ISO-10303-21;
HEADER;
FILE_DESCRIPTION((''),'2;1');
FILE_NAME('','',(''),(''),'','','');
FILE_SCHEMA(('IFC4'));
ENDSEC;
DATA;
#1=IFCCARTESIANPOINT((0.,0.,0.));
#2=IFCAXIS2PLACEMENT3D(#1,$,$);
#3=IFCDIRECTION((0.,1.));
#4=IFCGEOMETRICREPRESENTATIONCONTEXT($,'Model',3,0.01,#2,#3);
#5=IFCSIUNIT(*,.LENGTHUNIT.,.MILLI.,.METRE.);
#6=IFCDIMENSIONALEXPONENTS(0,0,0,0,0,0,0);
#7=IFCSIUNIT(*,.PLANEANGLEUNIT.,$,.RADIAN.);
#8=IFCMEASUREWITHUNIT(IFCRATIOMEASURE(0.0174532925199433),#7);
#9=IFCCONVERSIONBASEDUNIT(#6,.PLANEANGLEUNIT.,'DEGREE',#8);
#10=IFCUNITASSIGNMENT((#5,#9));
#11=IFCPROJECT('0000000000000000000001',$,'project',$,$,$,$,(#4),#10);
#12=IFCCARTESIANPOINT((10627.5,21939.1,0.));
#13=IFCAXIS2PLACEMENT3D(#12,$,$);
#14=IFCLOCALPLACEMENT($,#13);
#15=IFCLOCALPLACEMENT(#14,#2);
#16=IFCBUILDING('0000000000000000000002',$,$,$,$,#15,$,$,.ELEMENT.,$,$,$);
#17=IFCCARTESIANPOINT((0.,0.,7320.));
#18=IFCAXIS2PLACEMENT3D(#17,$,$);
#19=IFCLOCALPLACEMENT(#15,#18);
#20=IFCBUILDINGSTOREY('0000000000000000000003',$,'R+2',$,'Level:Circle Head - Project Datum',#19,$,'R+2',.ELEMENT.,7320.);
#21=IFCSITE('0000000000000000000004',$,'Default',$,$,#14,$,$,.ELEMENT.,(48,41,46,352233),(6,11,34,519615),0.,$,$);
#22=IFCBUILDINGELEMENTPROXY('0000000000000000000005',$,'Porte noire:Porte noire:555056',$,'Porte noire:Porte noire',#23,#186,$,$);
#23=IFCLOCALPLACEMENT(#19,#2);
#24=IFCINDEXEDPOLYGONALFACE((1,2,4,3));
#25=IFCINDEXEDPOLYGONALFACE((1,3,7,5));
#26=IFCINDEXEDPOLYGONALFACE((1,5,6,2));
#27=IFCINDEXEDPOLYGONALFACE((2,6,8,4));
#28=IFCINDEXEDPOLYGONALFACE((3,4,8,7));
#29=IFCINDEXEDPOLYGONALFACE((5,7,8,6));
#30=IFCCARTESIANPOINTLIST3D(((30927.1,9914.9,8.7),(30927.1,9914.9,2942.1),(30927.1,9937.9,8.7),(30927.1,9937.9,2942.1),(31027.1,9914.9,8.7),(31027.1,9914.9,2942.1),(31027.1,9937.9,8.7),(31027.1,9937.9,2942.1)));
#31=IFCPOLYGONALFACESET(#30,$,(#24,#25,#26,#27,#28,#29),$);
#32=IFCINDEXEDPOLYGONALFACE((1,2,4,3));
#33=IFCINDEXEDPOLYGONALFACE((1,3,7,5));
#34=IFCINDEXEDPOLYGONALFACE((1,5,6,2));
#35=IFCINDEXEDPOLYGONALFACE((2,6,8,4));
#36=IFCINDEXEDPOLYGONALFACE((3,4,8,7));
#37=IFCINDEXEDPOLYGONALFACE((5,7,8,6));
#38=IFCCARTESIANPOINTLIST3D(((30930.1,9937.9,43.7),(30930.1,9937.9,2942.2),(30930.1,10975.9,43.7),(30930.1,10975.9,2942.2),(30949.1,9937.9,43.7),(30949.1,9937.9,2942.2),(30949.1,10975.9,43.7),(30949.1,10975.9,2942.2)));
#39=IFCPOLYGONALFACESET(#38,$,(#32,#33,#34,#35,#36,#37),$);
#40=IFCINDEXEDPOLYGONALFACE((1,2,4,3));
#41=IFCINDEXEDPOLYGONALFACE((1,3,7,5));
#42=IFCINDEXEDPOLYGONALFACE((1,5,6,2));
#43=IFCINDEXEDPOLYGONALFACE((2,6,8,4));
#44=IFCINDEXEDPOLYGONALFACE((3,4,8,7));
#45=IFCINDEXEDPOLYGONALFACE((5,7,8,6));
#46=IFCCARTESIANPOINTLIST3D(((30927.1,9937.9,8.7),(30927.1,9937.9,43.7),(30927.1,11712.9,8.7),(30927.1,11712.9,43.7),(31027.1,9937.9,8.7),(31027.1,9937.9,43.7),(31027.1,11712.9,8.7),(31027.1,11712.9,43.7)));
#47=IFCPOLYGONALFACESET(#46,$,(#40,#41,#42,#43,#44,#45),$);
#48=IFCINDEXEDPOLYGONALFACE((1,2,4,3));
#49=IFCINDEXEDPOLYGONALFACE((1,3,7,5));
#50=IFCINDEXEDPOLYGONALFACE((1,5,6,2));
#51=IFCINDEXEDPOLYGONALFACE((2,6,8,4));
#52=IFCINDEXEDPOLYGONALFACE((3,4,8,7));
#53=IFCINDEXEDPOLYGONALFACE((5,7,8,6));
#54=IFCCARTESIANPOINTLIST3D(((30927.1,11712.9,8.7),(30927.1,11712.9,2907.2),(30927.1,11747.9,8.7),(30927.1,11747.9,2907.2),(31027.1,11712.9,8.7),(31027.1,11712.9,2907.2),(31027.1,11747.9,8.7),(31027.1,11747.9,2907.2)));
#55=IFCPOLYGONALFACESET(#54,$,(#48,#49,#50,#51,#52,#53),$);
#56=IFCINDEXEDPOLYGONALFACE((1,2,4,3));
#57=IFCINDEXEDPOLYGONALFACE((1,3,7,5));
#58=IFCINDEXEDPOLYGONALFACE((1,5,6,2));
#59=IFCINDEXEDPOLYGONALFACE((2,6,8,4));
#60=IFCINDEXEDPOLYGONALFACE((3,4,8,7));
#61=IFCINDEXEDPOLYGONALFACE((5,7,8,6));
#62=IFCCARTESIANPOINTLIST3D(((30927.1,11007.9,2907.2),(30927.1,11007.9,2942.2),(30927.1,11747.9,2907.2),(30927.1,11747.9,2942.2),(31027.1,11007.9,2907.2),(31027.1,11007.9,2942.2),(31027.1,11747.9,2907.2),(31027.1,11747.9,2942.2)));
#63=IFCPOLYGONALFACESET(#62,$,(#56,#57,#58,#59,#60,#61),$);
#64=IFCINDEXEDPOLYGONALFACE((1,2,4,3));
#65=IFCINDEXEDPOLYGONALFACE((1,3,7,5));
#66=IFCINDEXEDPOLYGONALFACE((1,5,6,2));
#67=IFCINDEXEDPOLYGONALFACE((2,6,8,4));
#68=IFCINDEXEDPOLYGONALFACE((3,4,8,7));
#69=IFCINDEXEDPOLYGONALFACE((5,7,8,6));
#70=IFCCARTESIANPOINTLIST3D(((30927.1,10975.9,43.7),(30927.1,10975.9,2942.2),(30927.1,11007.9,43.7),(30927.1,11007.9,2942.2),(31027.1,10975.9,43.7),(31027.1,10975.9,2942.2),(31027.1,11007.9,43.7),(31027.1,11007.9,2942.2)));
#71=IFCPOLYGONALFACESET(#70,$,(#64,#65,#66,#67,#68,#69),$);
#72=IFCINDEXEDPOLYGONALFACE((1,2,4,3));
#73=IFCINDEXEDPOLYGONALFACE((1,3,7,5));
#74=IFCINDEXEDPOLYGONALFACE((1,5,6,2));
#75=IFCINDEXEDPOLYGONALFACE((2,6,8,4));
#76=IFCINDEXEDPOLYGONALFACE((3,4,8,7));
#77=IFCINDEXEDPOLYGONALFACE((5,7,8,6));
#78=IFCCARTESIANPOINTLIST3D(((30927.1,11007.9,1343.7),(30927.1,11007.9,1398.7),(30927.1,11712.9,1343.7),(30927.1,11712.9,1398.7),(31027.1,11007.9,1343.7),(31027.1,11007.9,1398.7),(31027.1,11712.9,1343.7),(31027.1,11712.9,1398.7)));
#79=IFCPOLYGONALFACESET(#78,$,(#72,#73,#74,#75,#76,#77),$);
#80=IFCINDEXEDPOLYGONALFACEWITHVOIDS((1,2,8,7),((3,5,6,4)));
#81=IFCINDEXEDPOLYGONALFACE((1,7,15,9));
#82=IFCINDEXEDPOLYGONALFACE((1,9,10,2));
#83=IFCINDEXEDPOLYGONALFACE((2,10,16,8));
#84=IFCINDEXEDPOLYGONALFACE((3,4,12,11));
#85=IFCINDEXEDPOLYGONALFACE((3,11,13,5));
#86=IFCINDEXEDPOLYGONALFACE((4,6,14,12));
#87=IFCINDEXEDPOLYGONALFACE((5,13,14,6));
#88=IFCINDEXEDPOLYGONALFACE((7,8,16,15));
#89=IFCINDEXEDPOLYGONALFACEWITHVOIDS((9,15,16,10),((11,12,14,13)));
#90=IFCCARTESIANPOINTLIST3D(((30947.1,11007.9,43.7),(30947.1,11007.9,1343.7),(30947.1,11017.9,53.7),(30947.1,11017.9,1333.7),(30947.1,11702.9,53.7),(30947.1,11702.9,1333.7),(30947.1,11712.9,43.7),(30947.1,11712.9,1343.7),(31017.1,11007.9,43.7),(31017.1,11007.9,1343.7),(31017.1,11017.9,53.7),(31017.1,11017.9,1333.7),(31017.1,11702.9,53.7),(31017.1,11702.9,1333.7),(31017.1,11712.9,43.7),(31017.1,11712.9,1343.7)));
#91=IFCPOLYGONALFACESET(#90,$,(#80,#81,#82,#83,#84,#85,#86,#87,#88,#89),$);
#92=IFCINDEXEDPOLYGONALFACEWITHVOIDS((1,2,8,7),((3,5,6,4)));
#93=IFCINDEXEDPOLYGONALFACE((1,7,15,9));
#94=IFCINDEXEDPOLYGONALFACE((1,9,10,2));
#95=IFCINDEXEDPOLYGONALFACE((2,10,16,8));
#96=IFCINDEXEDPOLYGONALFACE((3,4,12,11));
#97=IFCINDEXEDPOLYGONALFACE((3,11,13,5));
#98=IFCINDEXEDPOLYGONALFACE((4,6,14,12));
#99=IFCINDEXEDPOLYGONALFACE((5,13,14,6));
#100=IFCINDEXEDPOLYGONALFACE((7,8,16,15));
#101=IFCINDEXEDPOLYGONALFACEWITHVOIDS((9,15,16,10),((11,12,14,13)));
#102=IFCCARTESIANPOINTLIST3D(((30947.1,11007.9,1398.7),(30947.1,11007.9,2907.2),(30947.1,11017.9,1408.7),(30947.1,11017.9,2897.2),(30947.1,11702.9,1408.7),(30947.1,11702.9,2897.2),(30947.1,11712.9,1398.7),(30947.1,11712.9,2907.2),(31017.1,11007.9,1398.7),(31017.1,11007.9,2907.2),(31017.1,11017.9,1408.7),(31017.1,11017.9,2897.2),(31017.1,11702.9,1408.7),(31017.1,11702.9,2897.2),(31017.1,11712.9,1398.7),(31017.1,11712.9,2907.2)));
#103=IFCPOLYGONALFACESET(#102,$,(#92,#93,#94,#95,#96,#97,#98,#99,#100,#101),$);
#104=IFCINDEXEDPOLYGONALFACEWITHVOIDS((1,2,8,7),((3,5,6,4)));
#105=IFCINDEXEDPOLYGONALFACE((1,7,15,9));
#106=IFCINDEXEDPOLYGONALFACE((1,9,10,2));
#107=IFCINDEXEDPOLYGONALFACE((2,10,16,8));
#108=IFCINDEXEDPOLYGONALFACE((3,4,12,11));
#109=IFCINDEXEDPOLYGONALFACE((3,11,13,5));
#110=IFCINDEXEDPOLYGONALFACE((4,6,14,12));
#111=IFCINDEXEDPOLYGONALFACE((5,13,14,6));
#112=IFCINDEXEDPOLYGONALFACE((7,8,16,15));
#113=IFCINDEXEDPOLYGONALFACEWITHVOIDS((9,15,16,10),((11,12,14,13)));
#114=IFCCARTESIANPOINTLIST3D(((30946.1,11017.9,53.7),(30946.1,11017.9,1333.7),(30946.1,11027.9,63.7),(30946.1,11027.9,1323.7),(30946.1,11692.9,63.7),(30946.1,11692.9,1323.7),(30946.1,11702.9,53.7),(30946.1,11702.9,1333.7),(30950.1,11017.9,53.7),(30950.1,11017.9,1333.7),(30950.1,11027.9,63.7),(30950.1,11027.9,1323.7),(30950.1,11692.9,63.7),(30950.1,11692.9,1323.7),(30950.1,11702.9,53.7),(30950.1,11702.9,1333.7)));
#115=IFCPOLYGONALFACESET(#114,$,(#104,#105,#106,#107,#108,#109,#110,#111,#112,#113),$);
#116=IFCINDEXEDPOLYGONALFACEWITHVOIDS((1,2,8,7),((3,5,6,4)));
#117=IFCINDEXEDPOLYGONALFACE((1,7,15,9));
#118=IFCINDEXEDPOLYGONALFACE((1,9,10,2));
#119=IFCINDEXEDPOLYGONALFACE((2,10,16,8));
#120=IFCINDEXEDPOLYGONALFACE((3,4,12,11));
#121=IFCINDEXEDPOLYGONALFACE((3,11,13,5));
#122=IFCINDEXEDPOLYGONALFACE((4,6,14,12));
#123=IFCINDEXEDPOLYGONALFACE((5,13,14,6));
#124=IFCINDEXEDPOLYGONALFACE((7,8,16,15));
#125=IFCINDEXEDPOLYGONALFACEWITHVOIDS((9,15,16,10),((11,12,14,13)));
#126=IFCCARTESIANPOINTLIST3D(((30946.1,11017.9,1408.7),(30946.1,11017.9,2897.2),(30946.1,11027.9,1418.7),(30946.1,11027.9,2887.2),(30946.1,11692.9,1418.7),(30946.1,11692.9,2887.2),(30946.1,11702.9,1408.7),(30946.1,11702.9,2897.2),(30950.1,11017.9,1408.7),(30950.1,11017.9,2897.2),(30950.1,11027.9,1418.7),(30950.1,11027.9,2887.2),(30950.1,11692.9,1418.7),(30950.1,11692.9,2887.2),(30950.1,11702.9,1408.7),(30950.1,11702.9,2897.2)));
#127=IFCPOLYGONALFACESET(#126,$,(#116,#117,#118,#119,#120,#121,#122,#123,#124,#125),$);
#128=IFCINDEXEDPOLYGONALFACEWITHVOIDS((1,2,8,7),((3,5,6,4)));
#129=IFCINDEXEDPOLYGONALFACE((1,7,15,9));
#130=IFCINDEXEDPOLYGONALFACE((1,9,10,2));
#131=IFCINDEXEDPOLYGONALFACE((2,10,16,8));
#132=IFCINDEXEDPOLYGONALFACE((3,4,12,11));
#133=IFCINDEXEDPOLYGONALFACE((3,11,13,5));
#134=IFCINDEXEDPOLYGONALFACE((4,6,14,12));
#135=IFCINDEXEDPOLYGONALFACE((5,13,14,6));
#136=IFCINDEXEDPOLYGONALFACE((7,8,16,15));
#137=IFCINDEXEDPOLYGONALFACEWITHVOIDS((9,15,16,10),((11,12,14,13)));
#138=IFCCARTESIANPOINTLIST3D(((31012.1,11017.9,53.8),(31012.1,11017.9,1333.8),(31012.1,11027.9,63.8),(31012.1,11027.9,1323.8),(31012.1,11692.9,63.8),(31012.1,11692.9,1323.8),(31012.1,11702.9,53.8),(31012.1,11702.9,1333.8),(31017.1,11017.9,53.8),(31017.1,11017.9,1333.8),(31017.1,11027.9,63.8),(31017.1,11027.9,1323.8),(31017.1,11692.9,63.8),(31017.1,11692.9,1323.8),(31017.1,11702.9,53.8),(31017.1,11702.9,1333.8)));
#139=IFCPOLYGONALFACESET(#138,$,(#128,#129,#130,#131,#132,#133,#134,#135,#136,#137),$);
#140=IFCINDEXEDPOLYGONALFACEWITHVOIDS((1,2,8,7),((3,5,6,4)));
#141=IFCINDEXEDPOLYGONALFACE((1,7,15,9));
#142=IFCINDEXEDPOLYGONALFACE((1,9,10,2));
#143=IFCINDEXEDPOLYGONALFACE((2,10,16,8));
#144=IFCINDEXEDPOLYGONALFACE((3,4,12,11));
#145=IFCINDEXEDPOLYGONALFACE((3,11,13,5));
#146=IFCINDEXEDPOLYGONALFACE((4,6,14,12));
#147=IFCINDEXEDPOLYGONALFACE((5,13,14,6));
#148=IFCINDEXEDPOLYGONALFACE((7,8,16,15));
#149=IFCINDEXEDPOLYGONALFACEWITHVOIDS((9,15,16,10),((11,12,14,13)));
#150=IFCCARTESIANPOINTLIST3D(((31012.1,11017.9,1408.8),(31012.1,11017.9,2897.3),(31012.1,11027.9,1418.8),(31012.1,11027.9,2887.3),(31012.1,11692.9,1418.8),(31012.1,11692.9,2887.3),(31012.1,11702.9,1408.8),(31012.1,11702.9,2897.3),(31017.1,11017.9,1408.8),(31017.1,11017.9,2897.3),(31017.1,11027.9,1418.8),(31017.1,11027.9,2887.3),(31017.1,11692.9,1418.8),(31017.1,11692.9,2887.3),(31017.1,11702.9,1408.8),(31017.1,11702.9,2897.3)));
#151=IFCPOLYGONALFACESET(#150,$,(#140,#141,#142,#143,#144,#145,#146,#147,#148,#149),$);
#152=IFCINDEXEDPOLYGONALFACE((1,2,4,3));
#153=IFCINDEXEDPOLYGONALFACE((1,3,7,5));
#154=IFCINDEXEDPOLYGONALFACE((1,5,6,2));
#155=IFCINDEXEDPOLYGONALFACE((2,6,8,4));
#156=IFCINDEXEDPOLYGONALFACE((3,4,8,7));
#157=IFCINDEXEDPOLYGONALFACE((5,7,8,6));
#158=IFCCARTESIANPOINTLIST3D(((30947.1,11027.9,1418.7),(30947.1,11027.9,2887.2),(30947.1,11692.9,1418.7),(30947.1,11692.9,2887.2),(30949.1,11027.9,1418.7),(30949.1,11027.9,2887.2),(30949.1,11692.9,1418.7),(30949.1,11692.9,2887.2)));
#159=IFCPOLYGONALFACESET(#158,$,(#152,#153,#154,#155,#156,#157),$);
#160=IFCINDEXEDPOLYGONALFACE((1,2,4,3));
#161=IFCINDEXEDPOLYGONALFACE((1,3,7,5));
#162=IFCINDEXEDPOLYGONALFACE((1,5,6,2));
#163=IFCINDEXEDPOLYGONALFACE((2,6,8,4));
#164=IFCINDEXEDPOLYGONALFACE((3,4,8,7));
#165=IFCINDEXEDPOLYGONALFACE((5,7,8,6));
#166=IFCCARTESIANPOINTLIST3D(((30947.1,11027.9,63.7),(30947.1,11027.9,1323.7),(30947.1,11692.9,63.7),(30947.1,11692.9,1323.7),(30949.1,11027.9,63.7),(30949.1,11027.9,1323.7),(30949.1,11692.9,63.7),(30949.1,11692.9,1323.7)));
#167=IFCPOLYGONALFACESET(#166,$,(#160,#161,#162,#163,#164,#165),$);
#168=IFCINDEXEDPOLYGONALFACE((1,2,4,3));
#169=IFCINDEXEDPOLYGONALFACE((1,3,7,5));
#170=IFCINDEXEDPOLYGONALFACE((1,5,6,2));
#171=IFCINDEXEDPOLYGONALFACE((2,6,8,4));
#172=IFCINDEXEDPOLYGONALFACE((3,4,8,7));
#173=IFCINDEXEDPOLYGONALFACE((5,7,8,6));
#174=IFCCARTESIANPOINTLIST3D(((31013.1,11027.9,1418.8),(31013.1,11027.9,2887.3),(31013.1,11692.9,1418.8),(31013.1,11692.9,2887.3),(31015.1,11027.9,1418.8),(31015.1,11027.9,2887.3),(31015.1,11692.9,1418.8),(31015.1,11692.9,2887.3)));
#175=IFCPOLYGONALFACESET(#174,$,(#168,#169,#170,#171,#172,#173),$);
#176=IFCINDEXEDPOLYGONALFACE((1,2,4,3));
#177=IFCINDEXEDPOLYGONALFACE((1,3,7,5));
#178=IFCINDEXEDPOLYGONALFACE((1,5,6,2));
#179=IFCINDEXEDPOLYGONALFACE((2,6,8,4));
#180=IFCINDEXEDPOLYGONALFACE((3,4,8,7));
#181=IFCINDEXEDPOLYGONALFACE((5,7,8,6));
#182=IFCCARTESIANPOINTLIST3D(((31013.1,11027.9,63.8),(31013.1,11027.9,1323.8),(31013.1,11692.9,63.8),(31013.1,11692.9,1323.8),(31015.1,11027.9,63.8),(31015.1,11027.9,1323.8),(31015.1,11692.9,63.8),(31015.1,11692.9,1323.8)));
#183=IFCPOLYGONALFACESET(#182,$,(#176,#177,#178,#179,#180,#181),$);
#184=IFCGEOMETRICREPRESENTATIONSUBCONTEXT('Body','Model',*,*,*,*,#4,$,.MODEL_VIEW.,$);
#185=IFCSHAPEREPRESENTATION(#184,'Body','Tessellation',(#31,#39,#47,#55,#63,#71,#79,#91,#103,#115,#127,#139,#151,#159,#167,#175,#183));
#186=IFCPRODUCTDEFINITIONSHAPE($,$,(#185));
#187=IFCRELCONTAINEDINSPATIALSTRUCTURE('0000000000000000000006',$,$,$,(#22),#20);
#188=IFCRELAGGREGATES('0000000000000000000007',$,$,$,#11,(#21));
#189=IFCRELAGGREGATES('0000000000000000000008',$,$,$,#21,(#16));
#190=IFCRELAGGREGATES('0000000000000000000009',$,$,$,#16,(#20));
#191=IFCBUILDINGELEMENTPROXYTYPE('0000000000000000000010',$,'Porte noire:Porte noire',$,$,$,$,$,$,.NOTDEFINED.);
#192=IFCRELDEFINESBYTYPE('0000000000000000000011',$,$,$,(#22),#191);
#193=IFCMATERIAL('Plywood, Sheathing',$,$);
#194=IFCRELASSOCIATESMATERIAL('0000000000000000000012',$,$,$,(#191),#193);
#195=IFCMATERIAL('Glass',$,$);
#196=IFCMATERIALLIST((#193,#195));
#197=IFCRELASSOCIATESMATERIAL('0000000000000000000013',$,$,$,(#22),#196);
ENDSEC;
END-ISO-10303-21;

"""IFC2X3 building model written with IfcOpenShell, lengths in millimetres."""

from ifc_helpers import new_model, entity, si_unit, converted_unit, direction, frame, frame_2d, origin, origin_2d_with_axis, place, context, subcontext, project, spatial, polyline, rectangle, outline, extrude, source, transform, mapped, material, material_list, type_object, type_shapes, element, save


model = new_model("IFC2X3")

# Units and contexts
model_context = context("Model", 3, precision=0.01, world=origin(), true_north=direction((0.0, 1.0)))
body_context = subcontext(model_context, "Body", "Model", "MODEL_VIEW")
ifc_project = project(units=[si_unit("LENGTHUNIT", "METRE", prefix="MILLI"), converted_unit("PLANEANGLEUNIT", "DEGREE", entity("IfcRatioMeasure", 0.0174532925199433), si_unit("PLANEANGLEUNIT", "RADIAN"), dimensions=[0, 0, 0, 0, 0, 0, 0])], contexts=[model_context])

# Site, building, storey
site_placement = place(None, frame((10627.5, 21939.1, 0.0)))
site = spatial("IfcSite", under=ifc_project, at=site_placement, Name="Default", CompositionType="ELEMENT", RefLatitude=(48, 41, 46, 352233), RefLongitude=(6, 11, 34, 519615), RefElevation=0.0)
building_placement = place(site_placement, origin())
building = spatial("IfcBuilding", under=site, at=building_placement, CompositionType="ELEMENT")
storey_placement = place(building_placement, frame((0.0, 0.0, 7320.0)))
storey = spatial("IfcBuildingStorey", under=building, at=storey_placement, Name="R+2", ObjectType="Level:Circle Head - Project Datum", LongName="R+2", CompositionType="ELEMENT", Elevation=7320.0)

# Building element proxy
ifc_material_1 = material(Name="Glass")
ifc_material_2 = material(Name="Plywood, Sheathing")
building_element_proxy_type_1 = type_object("IfcBuildingElementProxyType", Name="Porte noire:Porte noire", PredefinedType="NOTDEFINED", material=ifc_material_2)
shared_shape_1 = source(origin(), body_context, "Body", "SweptSolid", [
    extrude(rectangle(XDim=23.0, YDim=100.0, at=frame_2d((0.0, 0.0), x_axis=(1.0, 0.0))), frame((-950.9, 50.0, 8.7), z_axis=(0.0, 0.0, 1.0), x_axis=(-1.0, 0.0, 0.0)), (0.0, 0.0, 1.0), 2933.3),
    extrude(rectangle(XDim=1038.0, YDim=19.0, at=frame_2d((0.0, 0.0), x_axis=(1.0, 0.0))), frame((-420.4, 87.5, 43.7), z_axis=(0.0, 0.0, 1.0), x_axis=(-1.0, 0.0, 0.0)), (0.0, 0.0, 1.0), 2898.5),
    extrude(rectangle(XDim=1775.0, YDim=100.0, at=origin_2d_with_axis()), frame((-51.9, 50.0, 8.7), z_axis=(0.0, 0.0, 1.0), x_axis=(-1.0, 0.0, 0.0)), (0.0, 0.0, 1.0), 35.0),
    extrude(rectangle(XDim=35.0, YDim=100.0, at=origin_2d_with_axis()), frame((853.1, 50.0, 8.7), z_axis=(0.0, 0.0, 1.0), x_axis=(-1.0, 0.0, 0.0)), (0.0, 0.0, 1.0), 2898.5),
    extrude(rectangle(XDim=740.0, YDim=100.0, at=origin_2d_with_axis()), frame((500.6, 50.0, 2907.2), z_axis=(0.0, 0.0, 1.0), x_axis=(-1.0, 0.0, 0.0)), (0.0, 0.0, 1.0), 35.0),
    extrude(rectangle(XDim=32.0, YDim=100.0, at=origin_2d_with_axis()), frame((114.6, 50.0, 43.7), z_axis=(0.0, 0.0, 1.0), x_axis=(-1.0, 0.0, 0.0)), (0.0, 0.0, 1.0), 2898.5),
    extrude(rectangle(XDim=705.0, YDim=100.0, at=origin_2d_with_axis()), frame((483.1, 50.0, 1343.7), z_axis=(0.0, 0.0, 1.0), x_axis=(-1.0, 0.0, 0.0)), (0.0, 0.0, 1.0), 55.0),
    extrude(outline(polyline([(-352.5, -650.0), (352.5, -650.0), (352.5, 650.0), (-352.5, 650.0), (-352.5, -650.0)]), holes=[polyline([(342.5, 640.0), (342.5, -640.0), (-342.5, -640.0), (-342.5, 640.0), (342.5, 640.0)])]), frame((483.1, 10.0, 693.7), z_axis=(0.0, 1.0, 0.0), x_axis=(1.0, 0.0, 0.0)), (0.0, 0.0, 1.0), 70.0),
    extrude(outline(polyline([(-754.2, -352.5), (754.2, -352.5), (754.2, 352.5), (-754.2, 352.5), (-754.2, -352.5)]), holes=[polyline([(744.2, 342.5), (744.2, -342.5), (-744.2, -342.5), (-744.2, 342.5), (744.2, 342.5)])]), frame((483.1, 10.0, 2153.0), z_axis=(0.0, 1.0, 0.0), x_axis=(0.0, 0.0, 1.0)), (0.0, 0.0, 1.0), 70.0),
    extrude(outline(polyline([(-640.0, -342.5), (640.0, -342.5), (640.0, 342.5), (-640.0, 342.5), (-640.0, -342.5)]), holes=[polyline([(630.0, 332.5), (630.0, -332.5), (-630.0, -332.5), (-630.0, 332.5), (630.0, 332.5)])]), frame((483.1, 77.0, 693.7), z_axis=(0.0, 1.0, 0.0), x_axis=(0.0, 0.0, 1.0)), (0.0, 0.0, 1.0), 4.0),
    extrude(outline(polyline([(-744.2, -342.5), (744.2, -342.5), (744.2, 342.5), (-744.2, 342.5), (-744.2, -342.5)]), holes=[polyline([(734.2, 332.5), (734.2, -332.5), (-734.2, -332.5), (-734.2, 332.5), (734.2, 332.5)])]), frame((483.1, 77.0, 2153.0), z_axis=(0.0, 1.0, 0.0), x_axis=(0.0, 0.0, 1.0)), (0.0, 0.0, 1.0), 4.0),
    extrude(outline(polyline([(-640.0, -342.5), (640.0, -342.5), (640.0, 342.5), (-640.0, 342.5), (-640.0, -342.5)]), holes=[polyline([(630.0, 332.5), (630.0, -332.5), (-630.0, -332.5), (-630.0, 332.5), (630.0, 332.5)])]), frame((483.1, 10.0, 693.8), z_axis=(0.0, 1.0, 0.0), x_axis=(0.0, 0.0, 1.0)), (0.0, 0.0, 1.0), 5.0),
    extrude(outline(polyline([(-744.2, -342.5), (744.2, -342.5), (744.2, 342.5), (-744.2, 342.5), (-744.2, -342.5)]), holes=[polyline([(734.2, 332.5), (734.2, -332.5), (-734.2, -332.5), (-734.2, 332.5), (734.2, 332.5)])]), frame((483.1, 10.0, 2153.0), z_axis=(0.0, 1.0, 0.0), x_axis=(0.0, 0.0, 1.0)), (0.0, 0.0, 1.0), 5.0),
    extrude(rectangle(XDim=665.0, YDim=2.0, at=frame_2d((0.0, 0.0), x_axis=(1.0, 0.0))), frame((483.1, 79.0, 1418.7), z_axis=(0.0, 0.0, 1.0), x_axis=(-1.0, 0.0, 0.0)), (0.0, 0.0, 1.0), 1468.5),
    extrude(rectangle(XDim=665.0, YDim=2.0, at=frame_2d((0.0, 0.0), x_axis=(1.0, 0.0))), frame((483.1, 79.0, 63.7), z_axis=(0.0, 0.0, 1.0), x_axis=(-1.0, 0.0, 0.0)), (0.0, 0.0, 1.0), 1260.0),
    extrude(rectangle(XDim=665.0, YDim=2.0, at=frame_2d((0.0, 0.0), x_axis=(1.0, 0.0))), frame((483.1, 13.0, 1418.8), z_axis=(0.0, 0.0, 1.0), x_axis=(-1.0, 0.0, 0.0)), (0.0, 0.0, 1.0), 1468.5),
    extrude(rectangle(XDim=665.0, YDim=2.0, at=frame_2d((0.0, 0.0), x_axis=(1.0, 0.0))), frame((483.1, 13.0, 63.8), z_axis=(0.0, 0.0, 1.0), x_axis=(-1.0, 0.0, 0.0)), (0.0, 0.0, 1.0), 1260.0),
])
type_shapes(building_element_proxy_type_1, [shared_shape_1])
ifc_material_list_1 = material_list([ifc_material_2, ifc_material_1])
proxy_1_placement = place(storey_placement, frame((31027.1, 10877.3, 0.0), z_axis=(0.0, 0.0, 1.0), x_axis=(0.0, 1.0, 0.0)))
element("IfcBuildingElementProxy", 1, at=proxy_1_placement, inside=storey, type_object=building_element_proxy_type_1, material=ifc_material_list_1, Name="Porte noire:Porte noire:555056", ObjectType="Porte noire:Porte noire", context=body_context, shape_type="MappedRepresentation", body=[
    mapped(shared_shape_1, transform((0.0, 0.0, 0.0), scale=1.0)),
])

save(model, "model.ifc")
